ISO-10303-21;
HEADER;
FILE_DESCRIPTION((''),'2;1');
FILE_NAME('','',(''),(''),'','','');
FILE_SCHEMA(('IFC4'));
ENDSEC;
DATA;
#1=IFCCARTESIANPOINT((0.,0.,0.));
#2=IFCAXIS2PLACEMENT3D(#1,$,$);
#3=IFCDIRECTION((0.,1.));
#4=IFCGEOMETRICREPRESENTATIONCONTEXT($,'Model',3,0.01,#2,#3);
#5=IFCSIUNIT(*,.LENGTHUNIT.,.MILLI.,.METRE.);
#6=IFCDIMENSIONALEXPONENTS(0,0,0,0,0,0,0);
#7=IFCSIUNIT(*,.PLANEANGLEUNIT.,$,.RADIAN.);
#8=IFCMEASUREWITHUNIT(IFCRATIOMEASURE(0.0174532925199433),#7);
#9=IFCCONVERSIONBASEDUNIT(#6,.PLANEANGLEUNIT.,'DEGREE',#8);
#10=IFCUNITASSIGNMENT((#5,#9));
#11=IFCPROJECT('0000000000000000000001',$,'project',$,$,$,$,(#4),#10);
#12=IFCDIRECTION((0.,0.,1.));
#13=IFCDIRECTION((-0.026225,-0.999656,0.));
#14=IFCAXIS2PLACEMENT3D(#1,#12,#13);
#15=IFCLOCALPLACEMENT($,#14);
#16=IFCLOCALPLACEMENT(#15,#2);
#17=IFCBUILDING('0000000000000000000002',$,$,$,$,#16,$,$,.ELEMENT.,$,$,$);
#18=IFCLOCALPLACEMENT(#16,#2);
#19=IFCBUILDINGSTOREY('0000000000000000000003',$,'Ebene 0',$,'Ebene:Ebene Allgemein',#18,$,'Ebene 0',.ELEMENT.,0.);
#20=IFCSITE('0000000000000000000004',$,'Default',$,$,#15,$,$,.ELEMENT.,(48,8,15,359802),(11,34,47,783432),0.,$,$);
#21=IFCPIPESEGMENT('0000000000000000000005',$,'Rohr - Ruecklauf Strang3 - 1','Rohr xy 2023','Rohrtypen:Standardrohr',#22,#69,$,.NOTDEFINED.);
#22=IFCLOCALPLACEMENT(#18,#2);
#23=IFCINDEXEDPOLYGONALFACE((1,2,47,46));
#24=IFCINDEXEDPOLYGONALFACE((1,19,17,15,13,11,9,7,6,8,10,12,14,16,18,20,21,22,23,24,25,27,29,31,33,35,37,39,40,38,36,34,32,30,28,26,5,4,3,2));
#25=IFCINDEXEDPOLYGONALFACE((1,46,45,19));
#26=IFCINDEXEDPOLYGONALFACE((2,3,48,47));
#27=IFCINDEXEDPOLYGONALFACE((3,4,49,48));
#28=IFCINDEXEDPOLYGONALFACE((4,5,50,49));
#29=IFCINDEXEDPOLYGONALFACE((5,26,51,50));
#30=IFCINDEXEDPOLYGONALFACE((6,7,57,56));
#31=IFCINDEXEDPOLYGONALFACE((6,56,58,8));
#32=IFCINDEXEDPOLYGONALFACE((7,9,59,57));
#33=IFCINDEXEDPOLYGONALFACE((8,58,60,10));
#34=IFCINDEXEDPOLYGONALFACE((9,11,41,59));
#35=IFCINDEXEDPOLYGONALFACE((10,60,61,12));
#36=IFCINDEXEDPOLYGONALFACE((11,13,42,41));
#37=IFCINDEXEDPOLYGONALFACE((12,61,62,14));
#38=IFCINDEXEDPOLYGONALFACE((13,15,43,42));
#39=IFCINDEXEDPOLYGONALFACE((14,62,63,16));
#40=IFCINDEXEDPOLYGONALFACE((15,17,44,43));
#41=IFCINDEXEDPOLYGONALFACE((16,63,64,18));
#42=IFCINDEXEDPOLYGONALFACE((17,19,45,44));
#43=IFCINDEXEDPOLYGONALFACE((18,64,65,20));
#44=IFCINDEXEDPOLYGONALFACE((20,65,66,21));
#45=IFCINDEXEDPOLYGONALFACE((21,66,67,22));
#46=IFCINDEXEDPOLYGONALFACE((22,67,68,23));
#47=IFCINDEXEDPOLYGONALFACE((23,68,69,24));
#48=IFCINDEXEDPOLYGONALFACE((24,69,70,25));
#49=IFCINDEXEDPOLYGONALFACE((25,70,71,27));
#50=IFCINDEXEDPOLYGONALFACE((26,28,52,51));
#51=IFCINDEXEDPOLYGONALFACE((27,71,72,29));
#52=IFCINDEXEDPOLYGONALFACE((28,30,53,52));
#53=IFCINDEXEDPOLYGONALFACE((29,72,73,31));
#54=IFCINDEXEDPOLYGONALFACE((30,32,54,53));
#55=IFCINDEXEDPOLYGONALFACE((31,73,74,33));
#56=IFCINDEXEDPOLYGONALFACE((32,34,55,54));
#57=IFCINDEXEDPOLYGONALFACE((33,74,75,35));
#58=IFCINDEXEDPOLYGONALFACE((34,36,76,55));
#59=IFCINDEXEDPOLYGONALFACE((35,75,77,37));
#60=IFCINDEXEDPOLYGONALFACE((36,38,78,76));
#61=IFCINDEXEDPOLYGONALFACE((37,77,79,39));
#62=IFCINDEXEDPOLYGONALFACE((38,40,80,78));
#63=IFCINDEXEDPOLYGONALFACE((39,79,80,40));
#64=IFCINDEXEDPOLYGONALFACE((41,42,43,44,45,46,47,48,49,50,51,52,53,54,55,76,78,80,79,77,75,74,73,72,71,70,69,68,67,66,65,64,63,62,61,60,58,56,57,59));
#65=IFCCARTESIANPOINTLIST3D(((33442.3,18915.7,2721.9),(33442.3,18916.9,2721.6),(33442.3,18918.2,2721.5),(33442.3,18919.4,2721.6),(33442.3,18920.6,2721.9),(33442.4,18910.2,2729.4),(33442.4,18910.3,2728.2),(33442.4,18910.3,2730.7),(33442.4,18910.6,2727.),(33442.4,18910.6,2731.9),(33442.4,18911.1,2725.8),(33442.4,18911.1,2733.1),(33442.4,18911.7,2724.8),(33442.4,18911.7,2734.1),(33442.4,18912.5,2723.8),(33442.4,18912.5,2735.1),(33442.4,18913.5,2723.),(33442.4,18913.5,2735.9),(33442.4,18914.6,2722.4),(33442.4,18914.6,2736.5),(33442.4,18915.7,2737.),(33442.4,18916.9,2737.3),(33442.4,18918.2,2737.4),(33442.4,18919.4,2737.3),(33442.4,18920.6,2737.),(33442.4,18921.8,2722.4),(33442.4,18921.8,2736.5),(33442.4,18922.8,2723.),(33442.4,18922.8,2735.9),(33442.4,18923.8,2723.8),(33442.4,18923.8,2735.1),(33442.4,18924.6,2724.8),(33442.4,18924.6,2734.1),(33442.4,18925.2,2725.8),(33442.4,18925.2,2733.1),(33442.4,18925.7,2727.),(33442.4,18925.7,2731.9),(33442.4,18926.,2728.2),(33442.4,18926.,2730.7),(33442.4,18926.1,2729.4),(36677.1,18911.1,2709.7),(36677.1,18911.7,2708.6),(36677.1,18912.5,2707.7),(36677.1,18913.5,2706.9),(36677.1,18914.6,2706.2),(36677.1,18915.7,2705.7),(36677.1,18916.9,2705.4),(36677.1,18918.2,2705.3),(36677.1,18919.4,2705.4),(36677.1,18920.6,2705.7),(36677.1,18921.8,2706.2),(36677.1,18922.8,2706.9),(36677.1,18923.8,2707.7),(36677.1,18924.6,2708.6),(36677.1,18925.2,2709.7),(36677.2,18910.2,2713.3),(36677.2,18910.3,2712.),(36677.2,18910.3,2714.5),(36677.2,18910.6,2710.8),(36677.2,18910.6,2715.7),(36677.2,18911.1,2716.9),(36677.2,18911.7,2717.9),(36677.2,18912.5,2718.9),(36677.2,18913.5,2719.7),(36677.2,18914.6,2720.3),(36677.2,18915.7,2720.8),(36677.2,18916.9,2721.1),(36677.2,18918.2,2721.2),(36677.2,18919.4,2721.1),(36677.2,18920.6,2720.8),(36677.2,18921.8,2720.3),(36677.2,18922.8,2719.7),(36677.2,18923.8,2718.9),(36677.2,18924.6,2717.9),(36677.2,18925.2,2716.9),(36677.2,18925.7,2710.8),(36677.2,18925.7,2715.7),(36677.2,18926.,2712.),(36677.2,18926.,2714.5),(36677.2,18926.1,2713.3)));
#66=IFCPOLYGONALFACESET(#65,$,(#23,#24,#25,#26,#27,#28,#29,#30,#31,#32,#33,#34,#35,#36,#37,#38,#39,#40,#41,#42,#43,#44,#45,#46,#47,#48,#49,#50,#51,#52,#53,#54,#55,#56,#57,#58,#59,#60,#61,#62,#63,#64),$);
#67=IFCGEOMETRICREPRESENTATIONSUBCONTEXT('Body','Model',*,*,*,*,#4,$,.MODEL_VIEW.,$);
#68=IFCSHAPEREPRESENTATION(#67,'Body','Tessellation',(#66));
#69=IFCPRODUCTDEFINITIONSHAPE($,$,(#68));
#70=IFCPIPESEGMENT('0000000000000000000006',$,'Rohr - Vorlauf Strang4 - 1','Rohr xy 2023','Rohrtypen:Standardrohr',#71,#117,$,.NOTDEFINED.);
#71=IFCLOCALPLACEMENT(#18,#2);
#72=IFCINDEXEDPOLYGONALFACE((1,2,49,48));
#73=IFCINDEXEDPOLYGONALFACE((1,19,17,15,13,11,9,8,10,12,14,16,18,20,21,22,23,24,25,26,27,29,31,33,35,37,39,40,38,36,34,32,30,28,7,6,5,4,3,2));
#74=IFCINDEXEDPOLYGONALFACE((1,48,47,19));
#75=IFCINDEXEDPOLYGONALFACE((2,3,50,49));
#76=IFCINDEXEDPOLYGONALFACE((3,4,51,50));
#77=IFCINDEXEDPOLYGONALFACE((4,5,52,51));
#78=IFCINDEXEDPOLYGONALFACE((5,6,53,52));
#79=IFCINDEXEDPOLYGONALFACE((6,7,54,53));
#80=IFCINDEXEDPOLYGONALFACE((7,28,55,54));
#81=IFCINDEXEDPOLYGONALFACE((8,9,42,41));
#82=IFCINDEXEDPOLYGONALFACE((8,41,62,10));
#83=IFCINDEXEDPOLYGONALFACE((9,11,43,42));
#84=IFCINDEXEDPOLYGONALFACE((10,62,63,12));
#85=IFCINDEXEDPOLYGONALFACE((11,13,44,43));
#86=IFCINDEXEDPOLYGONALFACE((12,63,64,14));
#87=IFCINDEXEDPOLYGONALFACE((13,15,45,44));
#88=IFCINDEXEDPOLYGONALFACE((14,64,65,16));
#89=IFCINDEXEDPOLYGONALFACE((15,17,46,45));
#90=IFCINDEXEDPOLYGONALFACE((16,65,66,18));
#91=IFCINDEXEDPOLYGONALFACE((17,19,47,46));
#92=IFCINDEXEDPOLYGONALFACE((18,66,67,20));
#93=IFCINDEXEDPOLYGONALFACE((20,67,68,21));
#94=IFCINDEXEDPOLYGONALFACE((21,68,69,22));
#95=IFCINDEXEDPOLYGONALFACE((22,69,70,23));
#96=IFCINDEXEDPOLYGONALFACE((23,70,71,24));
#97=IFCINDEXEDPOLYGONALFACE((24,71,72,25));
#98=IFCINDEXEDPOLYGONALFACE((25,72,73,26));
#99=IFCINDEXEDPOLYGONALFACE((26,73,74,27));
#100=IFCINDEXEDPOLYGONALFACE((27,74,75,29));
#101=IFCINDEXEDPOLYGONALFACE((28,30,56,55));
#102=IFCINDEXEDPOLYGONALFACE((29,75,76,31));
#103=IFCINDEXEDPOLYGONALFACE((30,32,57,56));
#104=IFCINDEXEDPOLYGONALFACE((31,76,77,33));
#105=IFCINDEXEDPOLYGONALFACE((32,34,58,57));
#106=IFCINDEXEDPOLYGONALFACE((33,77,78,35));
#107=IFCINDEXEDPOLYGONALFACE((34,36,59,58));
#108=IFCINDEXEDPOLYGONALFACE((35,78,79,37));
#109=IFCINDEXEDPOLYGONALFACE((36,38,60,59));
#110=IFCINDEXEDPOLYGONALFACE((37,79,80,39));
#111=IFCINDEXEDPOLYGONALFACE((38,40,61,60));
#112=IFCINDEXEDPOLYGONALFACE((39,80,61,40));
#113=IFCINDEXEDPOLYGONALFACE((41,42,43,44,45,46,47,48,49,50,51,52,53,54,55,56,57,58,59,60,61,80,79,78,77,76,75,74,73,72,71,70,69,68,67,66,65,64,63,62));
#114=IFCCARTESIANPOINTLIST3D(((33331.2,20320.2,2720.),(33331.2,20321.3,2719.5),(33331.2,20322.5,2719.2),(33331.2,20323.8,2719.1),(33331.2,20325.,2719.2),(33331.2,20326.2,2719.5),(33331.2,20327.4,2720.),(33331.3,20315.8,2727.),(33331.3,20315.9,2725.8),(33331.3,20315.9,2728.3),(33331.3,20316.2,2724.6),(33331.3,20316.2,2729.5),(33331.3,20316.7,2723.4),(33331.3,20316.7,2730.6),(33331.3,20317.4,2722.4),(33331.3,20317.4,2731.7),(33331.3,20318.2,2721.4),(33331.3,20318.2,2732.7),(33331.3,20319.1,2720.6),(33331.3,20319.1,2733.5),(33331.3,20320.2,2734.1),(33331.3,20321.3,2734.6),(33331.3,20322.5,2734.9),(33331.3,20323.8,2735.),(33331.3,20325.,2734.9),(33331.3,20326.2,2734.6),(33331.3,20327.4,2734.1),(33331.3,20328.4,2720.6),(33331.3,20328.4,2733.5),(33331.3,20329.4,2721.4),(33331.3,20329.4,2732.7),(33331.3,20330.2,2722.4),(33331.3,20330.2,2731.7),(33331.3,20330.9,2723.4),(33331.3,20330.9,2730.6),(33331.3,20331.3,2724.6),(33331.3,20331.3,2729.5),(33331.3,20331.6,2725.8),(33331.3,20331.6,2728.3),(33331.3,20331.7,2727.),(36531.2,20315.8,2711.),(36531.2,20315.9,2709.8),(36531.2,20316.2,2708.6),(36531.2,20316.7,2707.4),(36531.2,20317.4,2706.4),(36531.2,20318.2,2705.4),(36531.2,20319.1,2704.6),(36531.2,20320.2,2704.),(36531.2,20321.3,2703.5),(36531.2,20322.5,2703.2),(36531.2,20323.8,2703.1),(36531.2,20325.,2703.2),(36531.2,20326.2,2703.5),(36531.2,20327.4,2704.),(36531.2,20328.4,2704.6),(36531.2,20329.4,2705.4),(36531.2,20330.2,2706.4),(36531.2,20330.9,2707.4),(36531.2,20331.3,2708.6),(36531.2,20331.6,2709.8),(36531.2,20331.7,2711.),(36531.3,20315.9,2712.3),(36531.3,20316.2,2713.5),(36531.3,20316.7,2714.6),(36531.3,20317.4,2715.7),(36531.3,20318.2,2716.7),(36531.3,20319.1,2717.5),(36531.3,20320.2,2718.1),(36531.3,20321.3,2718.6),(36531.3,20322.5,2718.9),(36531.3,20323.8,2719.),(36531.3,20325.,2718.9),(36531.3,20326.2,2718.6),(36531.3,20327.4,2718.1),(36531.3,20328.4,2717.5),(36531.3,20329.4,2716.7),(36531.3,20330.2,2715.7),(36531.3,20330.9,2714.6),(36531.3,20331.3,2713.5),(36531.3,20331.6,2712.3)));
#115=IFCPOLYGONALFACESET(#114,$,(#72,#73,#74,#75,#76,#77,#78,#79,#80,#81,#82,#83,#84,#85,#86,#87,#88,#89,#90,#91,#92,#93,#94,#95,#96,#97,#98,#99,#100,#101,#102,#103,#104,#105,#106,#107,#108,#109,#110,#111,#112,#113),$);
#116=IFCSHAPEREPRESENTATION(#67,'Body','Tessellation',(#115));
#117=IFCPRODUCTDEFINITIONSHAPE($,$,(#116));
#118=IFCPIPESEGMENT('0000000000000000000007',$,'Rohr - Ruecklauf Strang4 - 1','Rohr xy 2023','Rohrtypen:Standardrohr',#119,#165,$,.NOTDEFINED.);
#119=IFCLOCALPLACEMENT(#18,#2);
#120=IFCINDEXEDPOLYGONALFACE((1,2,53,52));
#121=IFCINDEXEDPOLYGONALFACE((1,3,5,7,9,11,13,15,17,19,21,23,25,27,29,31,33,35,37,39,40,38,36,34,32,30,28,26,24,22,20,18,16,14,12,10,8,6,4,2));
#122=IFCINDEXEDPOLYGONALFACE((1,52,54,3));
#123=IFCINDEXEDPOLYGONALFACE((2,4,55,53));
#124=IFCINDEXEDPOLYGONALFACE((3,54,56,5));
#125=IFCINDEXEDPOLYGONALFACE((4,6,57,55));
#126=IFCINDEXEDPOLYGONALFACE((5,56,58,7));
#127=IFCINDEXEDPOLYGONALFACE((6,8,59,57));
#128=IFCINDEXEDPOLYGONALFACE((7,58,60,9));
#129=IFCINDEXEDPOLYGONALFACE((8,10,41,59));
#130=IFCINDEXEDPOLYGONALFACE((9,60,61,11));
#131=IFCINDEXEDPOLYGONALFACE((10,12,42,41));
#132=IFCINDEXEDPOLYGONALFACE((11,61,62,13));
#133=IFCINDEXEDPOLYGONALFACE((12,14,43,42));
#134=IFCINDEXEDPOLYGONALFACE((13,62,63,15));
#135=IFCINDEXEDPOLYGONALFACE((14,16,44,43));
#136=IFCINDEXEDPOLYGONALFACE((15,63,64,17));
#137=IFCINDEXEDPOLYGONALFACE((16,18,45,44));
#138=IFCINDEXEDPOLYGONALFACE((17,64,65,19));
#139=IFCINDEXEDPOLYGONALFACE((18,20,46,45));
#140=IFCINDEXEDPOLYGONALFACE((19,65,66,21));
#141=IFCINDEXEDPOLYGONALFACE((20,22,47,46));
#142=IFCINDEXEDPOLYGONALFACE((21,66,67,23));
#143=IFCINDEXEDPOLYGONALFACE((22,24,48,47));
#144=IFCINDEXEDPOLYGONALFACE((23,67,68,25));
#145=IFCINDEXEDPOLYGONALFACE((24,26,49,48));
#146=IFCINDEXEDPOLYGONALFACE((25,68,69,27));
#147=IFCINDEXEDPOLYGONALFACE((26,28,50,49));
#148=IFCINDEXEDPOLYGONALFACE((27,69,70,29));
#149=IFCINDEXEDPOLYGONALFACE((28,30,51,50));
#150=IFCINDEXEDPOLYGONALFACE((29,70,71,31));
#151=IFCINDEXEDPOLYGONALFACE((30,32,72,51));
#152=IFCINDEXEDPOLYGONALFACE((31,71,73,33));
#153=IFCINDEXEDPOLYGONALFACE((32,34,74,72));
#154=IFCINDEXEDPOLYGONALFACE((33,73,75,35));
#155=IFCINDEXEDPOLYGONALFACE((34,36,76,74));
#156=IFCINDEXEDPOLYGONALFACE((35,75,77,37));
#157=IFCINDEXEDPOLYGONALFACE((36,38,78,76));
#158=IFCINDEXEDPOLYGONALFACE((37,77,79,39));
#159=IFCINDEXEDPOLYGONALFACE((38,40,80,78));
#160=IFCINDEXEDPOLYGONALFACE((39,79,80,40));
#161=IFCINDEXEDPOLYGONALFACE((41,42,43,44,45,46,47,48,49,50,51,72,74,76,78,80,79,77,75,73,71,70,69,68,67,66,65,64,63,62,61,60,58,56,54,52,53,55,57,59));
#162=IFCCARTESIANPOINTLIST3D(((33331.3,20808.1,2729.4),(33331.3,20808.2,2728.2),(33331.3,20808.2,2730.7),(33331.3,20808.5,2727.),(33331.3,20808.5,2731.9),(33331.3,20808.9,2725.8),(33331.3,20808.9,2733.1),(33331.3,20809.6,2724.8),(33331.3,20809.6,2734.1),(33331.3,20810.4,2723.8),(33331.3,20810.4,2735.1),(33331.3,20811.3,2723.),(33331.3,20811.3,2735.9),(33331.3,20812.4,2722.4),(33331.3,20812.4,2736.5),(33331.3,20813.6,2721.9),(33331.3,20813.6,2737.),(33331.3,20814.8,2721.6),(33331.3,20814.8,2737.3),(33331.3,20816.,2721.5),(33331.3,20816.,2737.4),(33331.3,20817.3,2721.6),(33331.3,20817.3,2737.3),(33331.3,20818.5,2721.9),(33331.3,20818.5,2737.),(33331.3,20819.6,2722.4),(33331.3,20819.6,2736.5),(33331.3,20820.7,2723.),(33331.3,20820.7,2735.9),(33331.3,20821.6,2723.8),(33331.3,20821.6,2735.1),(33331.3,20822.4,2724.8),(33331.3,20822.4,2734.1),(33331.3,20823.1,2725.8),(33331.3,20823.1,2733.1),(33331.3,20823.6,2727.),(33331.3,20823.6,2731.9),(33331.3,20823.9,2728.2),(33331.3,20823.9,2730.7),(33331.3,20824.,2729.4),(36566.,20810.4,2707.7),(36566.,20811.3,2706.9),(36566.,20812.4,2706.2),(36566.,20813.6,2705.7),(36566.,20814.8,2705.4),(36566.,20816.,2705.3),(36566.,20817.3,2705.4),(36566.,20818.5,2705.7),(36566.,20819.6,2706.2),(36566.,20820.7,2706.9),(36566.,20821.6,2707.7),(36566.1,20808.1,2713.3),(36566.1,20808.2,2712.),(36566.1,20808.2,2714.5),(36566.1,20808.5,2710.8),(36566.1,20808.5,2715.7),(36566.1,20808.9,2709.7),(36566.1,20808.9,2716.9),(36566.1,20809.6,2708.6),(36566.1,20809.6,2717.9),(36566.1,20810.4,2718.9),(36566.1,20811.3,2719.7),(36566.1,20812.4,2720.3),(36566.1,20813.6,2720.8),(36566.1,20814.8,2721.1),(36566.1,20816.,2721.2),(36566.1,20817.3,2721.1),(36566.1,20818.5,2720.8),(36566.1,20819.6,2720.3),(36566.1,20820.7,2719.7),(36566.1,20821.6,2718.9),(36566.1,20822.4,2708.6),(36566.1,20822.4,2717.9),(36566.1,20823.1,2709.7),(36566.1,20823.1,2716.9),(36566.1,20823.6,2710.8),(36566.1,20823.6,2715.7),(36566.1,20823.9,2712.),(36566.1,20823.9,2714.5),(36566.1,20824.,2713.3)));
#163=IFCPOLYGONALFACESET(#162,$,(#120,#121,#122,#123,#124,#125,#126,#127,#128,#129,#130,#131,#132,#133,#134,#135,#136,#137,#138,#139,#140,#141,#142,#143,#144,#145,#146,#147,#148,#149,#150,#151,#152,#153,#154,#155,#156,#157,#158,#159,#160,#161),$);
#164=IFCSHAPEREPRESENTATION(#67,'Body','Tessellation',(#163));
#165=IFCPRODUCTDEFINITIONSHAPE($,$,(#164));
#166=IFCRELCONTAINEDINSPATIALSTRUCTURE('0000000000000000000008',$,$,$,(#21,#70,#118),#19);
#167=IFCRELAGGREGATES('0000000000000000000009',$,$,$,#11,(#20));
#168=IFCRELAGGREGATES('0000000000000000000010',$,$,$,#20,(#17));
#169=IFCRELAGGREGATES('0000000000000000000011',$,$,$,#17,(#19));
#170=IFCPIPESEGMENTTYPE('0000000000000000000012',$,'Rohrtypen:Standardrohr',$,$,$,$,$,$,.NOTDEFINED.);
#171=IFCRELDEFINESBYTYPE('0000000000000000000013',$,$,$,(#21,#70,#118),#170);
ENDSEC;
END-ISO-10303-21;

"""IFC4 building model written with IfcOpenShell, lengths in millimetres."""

from ifc_helpers import new_model, entity, si_unit, converted_unit, direction, frame, origin, place, context, subcontext, project, spatial, indexed_curve, outline, extrude, type_object, element, save


model = new_model("IFC4")

# Units and contexts
model_context = context("Model", 3, precision=0.01, world=origin(), true_north=direction((0.0, 1.0)))
body_context = subcontext(model_context, "Body", "Model", "MODEL_VIEW")
ifc_project = project(units=[si_unit("LENGTHUNIT", "METRE", prefix="MILLI"), converted_unit("PLANEANGLEUNIT", "DEGREE", entity("IfcRatioMeasure", 0.0174532925199433), si_unit("PLANEANGLEUNIT", "RADIAN"), dimensions=[0, 0, 0, 0, 0, 0, 0])], contexts=[model_context])

# Site, building, storey
site_placement = place(None, frame((0.0, 0.0, 0.0), z_axis=(0.0, 0.0, 1.0), x_axis=(-0.026225, -0.999656, 0.0)))
site = spatial("IfcSite", under=ifc_project, at=site_placement, Name="Default", CompositionType="ELEMENT", RefLatitude=(48, 8, 15, 359802), RefLongitude=(11, 34, 47, 783432), RefElevation=0.0)
building_placement = place(site_placement, origin())
building = spatial("IfcBuilding", under=site, at=building_placement, CompositionType="ELEMENT")
storey_placement = place(building_placement, origin())
storey = spatial("IfcBuildingStorey", under=building, at=storey_placement, Name="Ebene 0", ObjectType="Ebene:Ebene Allgemein", LongName="Ebene 0", CompositionType="ELEMENT", Elevation=0.0)

# Pipe segments
pipe_segment_type = type_object("IfcPipeSegmentType", Name="Rohrtypen:Standardrohr", PredefinedType="NOTDEFINED")
pipe_segment_1_placement = place(storey_placement, origin())
element("IfcPipeSegment", 1, at=pipe_segment_1_placement, inside=storey, type_object=pipe_segment_type, Name="Rohr - Ruecklauf Strang3 - 1", Description="Rohr xy 2023", ObjectType="Rohrtypen:Standardrohr", PredefinedType="NOTDEFINED", context=body_context, shape_type="SweptSolid", body=[
    extrude(outline(indexed_curve([(7.9, 0.0), (7.8, 1.2), (7.6, 2.5), (7.1, 3.6), (6.4, 4.7), (5.6, 5.6), (4.7, 6.4), (3.6, 7.1), (2.5, 7.6), (1.2, 7.8), (0.0, 7.9), (-1.2, 7.8), (-2.5, 7.6), (-3.6, 7.1), (-4.7, 6.4), (-5.6, 5.6), (-6.4, 4.7), (-7.1, 3.6), (-7.6, 2.5), (-7.8, 1.2), (-7.9, 0.0), (-7.8, -1.2), (-7.6, -2.5), (-7.1, -3.6), (-6.4, -4.7), (-5.6, -5.6), (-4.7, -6.4), (-3.6, -7.1), (-2.5, -7.6), (-1.2, -7.8), (0.0, -7.9), (1.2, -7.8), (2.5, -7.6), (3.6, -7.1), (4.7, -6.4), (5.6, -5.6), (6.4, -4.7), (7.1, -3.6), (7.6, -2.5), (7.8, -1.2), (7.9, 0.0)], self_intersect=False)), frame((36677.2, 18918.2, 2713.3), z_axis=(-0.999988, 0.0, 0.005), x_axis=(0.0, 1.0, 0.0)), (0.0, 0.0, 1.0), 3234.8),
])
pipe_segment_2_placement = place(storey_placement, origin())
element("IfcPipeSegment", 2, at=pipe_segment_2_placement, inside=storey, type_object=pipe_segment_type, Name="Rohr - Vorlauf Strang4 - 1", Description="Rohr xy 2023", ObjectType="Rohrtypen:Standardrohr", PredefinedType="NOTDEFINED", context=body_context, shape_type="SweptSolid", body=[
    extrude(outline(indexed_curve([(7.9, 0.0), (7.8, 1.2), (7.6, 2.5), (7.1, 3.6), (6.4, 4.7), (5.6, 5.6), (4.7, 6.4), (3.6, 7.1), (2.5, 7.6), (1.2, 7.8), (0.0, 7.9), (-1.2, 7.8), (-2.5, 7.6), (-3.6, 7.1), (-4.7, 6.4), (-5.6, 5.6), (-6.4, 4.7), (-7.1, 3.6), (-7.6, 2.5), (-7.8, 1.2), (-7.9, 0.0), (-7.8, -1.2), (-7.6, -2.5), (-7.1, -3.6), (-6.4, -4.7), (-5.6, -5.6), (-4.7, -6.4), (-3.6, -7.1), (-2.5, -7.6), (-1.2, -7.8), (0.0, -7.9), (1.2, -7.8), (2.5, -7.6), (3.6, -7.1), (4.7, -6.4), (5.6, -5.6), (6.4, -4.7), (7.1, -3.6), (7.6, -2.5), (7.8, -1.2), (7.9, 0.0)], self_intersect=False)), frame((36531.2, 20323.8, 2711.0), z_axis=(-0.999988, 0.0, 0.005), x_axis=(0.0, 1.0, 0.0)), (0.0, 0.0, 1.0), 3200.0),
])
pipe_segment_3_placement = place(storey_placement, origin())
element("IfcPipeSegment", 3, at=pipe_segment_3_placement, inside=storey, type_object=pipe_segment_type, Name="Rohr - Ruecklauf Strang4 - 1", Description="Rohr xy 2023", ObjectType="Rohrtypen:Standardrohr", PredefinedType="NOTDEFINED", context=body_context, shape_type="SweptSolid", body=[
    extrude(outline(indexed_curve([(7.9, 0.0), (7.8, 1.2), (7.6, 2.5), (7.1, 3.6), (6.4, 4.7), (5.6, 5.6), (4.7, 6.4), (3.6, 7.1), (2.5, 7.6), (1.2, 7.8), (0.0, 7.9), (-1.2, 7.8), (-2.5, 7.6), (-3.6, 7.1), (-4.7, 6.4), (-5.6, 5.6), (-6.4, 4.7), (-7.1, 3.6), (-7.6, 2.5), (-7.8, 1.2), (-7.9, 0.0), (-7.8, -1.2), (-7.6, -2.5), (-7.1, -3.6), (-6.4, -4.7), (-5.6, -5.6), (-4.7, -6.4), (-3.6, -7.1), (-2.5, -7.6), (-1.2, -7.8), (0.0, -7.9), (1.2, -7.8), (2.5, -7.6), (3.6, -7.1), (4.7, -6.4), (5.6, -5.6), (6.4, -4.7), (7.1, -3.6), (7.6, -2.5), (7.8, -1.2), (7.9, 0.0)], self_intersect=False)), frame((36566.1, 20816.0, 2713.3), z_axis=(-0.999988, 0.0, 0.005), x_axis=(0.0, 1.0, 0.0)), (0.0, 0.0, 1.0), 3234.8),
])

save(model, "model.ifc")
